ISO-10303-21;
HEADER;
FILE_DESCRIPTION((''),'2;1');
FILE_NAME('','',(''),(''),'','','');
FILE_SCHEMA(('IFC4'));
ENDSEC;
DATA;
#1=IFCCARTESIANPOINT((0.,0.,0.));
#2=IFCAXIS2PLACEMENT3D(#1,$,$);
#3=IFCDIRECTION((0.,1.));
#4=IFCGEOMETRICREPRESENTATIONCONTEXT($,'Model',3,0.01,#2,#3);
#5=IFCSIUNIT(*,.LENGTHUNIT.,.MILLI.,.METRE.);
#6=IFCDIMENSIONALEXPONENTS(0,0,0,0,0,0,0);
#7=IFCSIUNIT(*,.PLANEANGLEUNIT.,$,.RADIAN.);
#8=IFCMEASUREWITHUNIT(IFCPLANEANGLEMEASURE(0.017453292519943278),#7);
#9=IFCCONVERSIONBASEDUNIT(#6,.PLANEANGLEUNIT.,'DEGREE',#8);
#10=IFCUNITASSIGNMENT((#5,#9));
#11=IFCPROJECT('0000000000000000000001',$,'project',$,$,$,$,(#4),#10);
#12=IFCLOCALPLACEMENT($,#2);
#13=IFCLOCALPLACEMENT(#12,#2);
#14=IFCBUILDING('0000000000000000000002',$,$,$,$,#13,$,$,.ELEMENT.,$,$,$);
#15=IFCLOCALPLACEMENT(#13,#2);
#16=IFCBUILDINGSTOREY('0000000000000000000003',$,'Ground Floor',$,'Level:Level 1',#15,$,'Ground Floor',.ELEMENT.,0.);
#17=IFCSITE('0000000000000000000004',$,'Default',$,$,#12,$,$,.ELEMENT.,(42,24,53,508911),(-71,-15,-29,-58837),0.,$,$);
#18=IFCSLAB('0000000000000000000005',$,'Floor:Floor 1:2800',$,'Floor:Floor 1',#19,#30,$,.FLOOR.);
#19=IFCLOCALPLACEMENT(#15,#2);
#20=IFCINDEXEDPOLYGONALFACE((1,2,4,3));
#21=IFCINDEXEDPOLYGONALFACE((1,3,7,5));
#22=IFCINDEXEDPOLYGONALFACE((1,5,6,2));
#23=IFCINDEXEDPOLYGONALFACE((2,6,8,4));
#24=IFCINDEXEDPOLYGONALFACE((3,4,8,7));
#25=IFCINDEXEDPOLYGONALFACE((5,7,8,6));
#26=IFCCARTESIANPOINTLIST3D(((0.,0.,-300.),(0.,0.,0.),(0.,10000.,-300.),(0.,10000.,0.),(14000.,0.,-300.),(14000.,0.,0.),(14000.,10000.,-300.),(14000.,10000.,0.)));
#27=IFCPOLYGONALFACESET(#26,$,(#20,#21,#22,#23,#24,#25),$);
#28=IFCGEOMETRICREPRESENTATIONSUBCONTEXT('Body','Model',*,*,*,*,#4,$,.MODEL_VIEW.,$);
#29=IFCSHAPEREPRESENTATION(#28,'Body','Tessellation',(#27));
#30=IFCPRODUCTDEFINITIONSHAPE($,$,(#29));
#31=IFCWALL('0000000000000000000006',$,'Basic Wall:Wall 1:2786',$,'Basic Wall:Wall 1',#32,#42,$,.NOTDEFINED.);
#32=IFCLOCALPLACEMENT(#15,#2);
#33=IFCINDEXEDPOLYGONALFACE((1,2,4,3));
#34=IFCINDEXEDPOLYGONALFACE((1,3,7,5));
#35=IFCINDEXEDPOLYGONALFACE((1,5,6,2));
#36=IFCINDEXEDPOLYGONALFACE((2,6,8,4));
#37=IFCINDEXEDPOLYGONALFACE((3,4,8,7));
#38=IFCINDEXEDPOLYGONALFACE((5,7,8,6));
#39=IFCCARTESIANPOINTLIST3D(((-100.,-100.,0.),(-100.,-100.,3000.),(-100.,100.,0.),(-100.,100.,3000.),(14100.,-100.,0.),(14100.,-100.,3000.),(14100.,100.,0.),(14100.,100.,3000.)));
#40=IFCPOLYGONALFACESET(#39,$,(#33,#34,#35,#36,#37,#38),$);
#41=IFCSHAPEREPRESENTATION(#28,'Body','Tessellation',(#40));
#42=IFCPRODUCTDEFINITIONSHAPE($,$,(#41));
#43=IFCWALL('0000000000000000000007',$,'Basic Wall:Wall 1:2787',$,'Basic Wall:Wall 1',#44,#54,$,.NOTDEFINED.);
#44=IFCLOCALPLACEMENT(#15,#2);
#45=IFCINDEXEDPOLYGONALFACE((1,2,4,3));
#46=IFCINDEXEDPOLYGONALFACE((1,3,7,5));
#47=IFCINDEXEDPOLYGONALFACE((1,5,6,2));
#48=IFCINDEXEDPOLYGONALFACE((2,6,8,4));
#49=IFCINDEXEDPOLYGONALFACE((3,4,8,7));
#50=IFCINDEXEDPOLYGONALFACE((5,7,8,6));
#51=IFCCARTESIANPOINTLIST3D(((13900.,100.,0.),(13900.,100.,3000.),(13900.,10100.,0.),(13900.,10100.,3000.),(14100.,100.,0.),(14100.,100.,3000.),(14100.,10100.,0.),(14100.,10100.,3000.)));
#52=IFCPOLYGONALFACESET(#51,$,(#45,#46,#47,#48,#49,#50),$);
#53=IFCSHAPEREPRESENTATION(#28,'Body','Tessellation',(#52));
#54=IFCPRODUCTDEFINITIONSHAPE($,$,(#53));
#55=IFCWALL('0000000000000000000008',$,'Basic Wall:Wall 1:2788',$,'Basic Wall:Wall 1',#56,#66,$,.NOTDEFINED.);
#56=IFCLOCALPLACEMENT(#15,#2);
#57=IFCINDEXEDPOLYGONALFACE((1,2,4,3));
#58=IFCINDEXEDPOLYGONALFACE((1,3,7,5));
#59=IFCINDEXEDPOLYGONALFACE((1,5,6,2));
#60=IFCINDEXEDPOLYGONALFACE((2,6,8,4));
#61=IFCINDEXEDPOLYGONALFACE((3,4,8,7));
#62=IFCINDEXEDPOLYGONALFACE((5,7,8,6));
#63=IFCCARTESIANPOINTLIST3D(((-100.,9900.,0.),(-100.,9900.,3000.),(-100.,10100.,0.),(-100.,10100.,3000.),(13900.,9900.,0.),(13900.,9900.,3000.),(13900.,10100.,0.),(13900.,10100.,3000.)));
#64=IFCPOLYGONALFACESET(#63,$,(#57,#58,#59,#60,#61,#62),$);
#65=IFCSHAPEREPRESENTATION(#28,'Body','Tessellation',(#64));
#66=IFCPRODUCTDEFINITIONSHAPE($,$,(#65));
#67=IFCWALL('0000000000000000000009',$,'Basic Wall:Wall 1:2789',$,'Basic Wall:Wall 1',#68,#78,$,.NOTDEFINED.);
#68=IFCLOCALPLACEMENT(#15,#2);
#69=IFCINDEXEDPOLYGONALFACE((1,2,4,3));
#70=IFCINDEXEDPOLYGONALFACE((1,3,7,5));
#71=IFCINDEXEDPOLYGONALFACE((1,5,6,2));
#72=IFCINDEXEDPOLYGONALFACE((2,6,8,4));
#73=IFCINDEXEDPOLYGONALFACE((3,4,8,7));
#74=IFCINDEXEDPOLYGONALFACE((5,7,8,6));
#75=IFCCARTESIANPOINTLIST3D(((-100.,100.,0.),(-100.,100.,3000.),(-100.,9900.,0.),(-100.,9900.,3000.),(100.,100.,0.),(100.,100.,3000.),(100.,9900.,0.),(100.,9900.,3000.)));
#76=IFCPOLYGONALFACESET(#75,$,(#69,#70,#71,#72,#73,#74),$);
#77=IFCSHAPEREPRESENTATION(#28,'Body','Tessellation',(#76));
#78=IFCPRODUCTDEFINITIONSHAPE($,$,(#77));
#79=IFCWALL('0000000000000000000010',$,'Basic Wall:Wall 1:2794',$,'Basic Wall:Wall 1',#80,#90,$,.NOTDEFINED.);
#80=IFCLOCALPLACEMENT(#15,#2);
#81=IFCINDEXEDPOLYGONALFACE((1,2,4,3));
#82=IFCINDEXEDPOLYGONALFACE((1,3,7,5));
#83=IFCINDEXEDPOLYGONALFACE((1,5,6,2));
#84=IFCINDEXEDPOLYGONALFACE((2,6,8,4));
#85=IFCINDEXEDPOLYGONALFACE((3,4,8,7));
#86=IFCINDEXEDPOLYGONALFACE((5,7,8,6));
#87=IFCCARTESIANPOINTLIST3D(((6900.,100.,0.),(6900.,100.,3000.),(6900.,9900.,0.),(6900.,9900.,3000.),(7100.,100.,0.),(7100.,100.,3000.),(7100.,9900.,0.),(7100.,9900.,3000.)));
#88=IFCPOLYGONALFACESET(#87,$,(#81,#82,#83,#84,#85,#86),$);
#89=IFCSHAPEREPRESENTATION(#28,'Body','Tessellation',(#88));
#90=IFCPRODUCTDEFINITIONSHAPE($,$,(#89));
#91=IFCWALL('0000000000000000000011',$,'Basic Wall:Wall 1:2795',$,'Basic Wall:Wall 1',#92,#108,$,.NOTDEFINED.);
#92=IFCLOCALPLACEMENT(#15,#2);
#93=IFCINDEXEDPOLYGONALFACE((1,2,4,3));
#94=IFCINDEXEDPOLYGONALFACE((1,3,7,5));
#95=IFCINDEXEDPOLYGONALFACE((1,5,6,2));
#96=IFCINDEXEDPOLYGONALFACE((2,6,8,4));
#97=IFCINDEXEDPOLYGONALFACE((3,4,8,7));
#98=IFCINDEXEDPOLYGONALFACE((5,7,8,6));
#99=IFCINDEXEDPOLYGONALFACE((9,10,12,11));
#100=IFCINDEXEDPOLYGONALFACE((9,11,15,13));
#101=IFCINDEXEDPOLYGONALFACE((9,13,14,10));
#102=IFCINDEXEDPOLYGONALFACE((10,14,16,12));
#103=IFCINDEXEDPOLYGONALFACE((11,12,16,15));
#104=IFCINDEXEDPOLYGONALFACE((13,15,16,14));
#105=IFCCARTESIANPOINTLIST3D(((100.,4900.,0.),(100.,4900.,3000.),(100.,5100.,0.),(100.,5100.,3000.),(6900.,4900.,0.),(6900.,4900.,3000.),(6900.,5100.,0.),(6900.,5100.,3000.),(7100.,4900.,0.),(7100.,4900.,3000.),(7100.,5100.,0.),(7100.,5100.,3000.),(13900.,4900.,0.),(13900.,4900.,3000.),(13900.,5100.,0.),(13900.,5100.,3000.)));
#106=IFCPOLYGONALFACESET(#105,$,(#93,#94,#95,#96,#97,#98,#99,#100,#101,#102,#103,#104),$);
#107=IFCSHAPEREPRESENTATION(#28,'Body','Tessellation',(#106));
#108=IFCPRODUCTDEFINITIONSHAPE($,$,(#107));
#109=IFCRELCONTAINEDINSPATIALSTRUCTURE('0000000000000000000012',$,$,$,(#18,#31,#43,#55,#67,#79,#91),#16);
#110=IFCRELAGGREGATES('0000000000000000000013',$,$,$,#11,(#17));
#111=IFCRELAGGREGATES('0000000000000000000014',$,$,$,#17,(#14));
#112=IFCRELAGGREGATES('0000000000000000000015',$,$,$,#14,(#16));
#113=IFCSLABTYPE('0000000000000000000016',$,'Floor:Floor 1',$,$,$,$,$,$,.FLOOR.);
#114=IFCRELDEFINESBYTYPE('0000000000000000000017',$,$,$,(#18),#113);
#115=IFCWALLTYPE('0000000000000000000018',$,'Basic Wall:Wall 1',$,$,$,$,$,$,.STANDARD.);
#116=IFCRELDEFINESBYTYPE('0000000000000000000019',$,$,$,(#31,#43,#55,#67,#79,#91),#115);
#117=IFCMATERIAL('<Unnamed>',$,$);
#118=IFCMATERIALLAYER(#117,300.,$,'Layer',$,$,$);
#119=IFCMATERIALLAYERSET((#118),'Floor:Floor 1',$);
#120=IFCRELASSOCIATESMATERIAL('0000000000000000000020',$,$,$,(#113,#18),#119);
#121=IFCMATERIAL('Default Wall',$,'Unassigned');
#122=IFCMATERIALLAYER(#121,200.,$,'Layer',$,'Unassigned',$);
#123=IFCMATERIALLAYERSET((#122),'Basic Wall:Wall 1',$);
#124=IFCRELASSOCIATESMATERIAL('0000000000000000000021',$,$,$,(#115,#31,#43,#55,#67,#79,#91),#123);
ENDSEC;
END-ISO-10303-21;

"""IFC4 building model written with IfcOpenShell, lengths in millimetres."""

from ifc_helpers import new_model, entity, si_unit, converted_unit, direction, frame, frame_2d, origin, origin_2d_with_axis, place, context, subcontext, project, spatial, rectangle, extrude, material, layer, layer_set, layer_usage, type_object, element, save


model = new_model("IFC4")

# Units and contexts
model_context = context("Model", 3, precision=0.01, world=origin(), true_north=direction((0.0, 1.0)))
body_context = subcontext(model_context, "Body", "Model", "MODEL_VIEW")
ifc_project = project(units=[si_unit("LENGTHUNIT", "METRE", prefix="MILLI"), converted_unit("PLANEANGLEUNIT", "DEGREE", entity("IfcPlaneAngleMeasure", 0.017453292519943278), si_unit("PLANEANGLEUNIT", "RADIAN"), dimensions=[0, 0, 0, 0, 0, 0, 0])], contexts=[model_context])

# Site, building, storey
site_placement = place(None, origin())
site = spatial("IfcSite", under=ifc_project, at=site_placement, Name="Default", CompositionType="ELEMENT", RefLatitude=(42, 24, 53, 508911), RefLongitude=(-71, -15, -29, -58837), RefElevation=0.0)
building_placement = place(site_placement, origin())
building = spatial("IfcBuilding", under=site, at=building_placement, CompositionType="ELEMENT")
storey_placement = place(building_placement, origin())
storey = spatial("IfcBuildingStorey", under=building, at=storey_placement, Name="Ground Floor", ObjectType="Level:Level 1", LongName="Ground Floor", CompositionType="ELEMENT", Elevation=0.0)

# Slab
ifc_material_1 = material(Name="<Unnamed>")
ifc_layer_1 = layer(ifc_material_1, 300.0, Name="Layer")
ifc_layer_set_1 = layer_set([ifc_layer_1], Name="Floor:Floor 1")
ifc_layer_usage_1 = layer_usage(ifc_layer_set_1, "AXIS3", "POSITIVE", 0.0)
slab_type = type_object("IfcSlabType", Name="Floor:Floor 1", PredefinedType="FLOOR", material=ifc_layer_set_1)
slab_placement = place(storey_placement, origin())
element("IfcSlab", 1, at=slab_placement, inside=storey, type_object=slab_type, material=ifc_layer_usage_1, Name="Floor:Floor 1:2800", ObjectType="Floor:Floor 1", PredefinedType="FLOOR", context=body_context, shape_type="SweptSolid", body=[
    extrude(rectangle(XDim=10000.0, YDim=14000.0, at=origin_2d_with_axis()), frame((7000.0, 5000.0, 0.0), z_axis=(0.0, 0.0, -1.0), x_axis=(0.0, 1.0, 0.0)), (0.0, 0.0, 1.0), 300.0),
])

# Walls
ifc_material_2 = material(Name="Default Wall", Category="Unassigned")
ifc_layer_2 = layer(ifc_material_2, 200.0, Name="Layer", Category="Unassigned")
ifc_layer_set_2 = layer_set([ifc_layer_2], Name="Basic Wall:Wall 1")
ifc_layer_usage_2 = layer_usage(ifc_layer_set_2, "AXIS2", "NEGATIVE", 100.0)
wall_type = type_object("IfcWallType", Name="Basic Wall:Wall 1", PredefinedType="STANDARD", material=ifc_layer_set_2)
wall_1_placement = place(storey_placement, frame((-100.0, 0.0, 0.0)))
element("IfcWall", 2, at=wall_1_placement, inside=storey, type_object=wall_type, material=ifc_layer_usage_2, Name="Basic Wall:Wall 1:2786", ObjectType="Basic Wall:Wall 1", PredefinedType="NOTDEFINED", context=body_context, shape_type="SweptSolid", body=[
    extrude(rectangle(XDim=14200.0, YDim=200.0, at=frame_2d((7100.0, 0.0), x_axis=(-1.0, 0.0))), origin(), (0.0, 0.0, 1.0), 3000.0),
])
ifc_layer_usage_3 = layer_usage(ifc_layer_set_2, "AXIS2", "NEGATIVE", 100.0)
wall_2_placement = place(storey_placement, frame((14000.0, 100.0, 0.0), z_axis=(0.0, 0.0, 1.0), x_axis=(0.0, 1.0, 0.0)))
element("IfcWall", 3, at=wall_2_placement, inside=storey, type_object=wall_type, material=ifc_layer_usage_3, Name="Basic Wall:Wall 1:2787", ObjectType="Basic Wall:Wall 1", PredefinedType="NOTDEFINED", context=body_context, shape_type="SweptSolid", body=[
    extrude(rectangle(XDim=10000.0, YDim=200.0, at=frame_2d((5000.0, 0.0), x_axis=(-1.0, 0.0))), origin(), (0.0, 0.0, 1.0), 3000.0),
])
ifc_layer_usage_4 = layer_usage(ifc_layer_set_2, "AXIS2", "NEGATIVE", 100.0)
wall_3_placement = place(storey_placement, frame((13900.0, 10000.0, 0.0), z_axis=(0.0, 0.0, 1.0), x_axis=(-1.0, 0.0, 0.0)))
element("IfcWall", 4, at=wall_3_placement, inside=storey, type_object=wall_type, material=ifc_layer_usage_4, Name="Basic Wall:Wall 1:2788", ObjectType="Basic Wall:Wall 1", PredefinedType="NOTDEFINED", context=body_context, shape_type="SweptSolid", body=[
    extrude(rectangle(XDim=14000.0, YDim=200.0, at=frame_2d((7000.0, 0.0), x_axis=(-1.0, 0.0))), origin(), (0.0, 0.0, 1.0), 3000.0),
])
ifc_layer_usage_5 = layer_usage(ifc_layer_set_2, "AXIS2", "NEGATIVE", 100.0)
wall_4_placement = place(storey_placement, frame((0.0, 9900.0, 0.0), z_axis=(0.0, 0.0, 1.0), x_axis=(0.0, -1.0, 0.0)))
element("IfcWall", 5, at=wall_4_placement, inside=storey, type_object=wall_type, material=ifc_layer_usage_5, Name="Basic Wall:Wall 1:2789", ObjectType="Basic Wall:Wall 1", PredefinedType="NOTDEFINED", context=body_context, shape_type="SweptSolid", body=[
    extrude(rectangle(XDim=9800.0, YDim=200.0, at=frame_2d((4900.0, 0.0), x_axis=(-1.0, 0.0))), origin(), (0.0, 0.0, 1.0), 3000.0),
])
ifc_layer_usage_6 = layer_usage(ifc_layer_set_2, "AXIS2", "NEGATIVE", 100.0)
wall_5_placement = place(storey_placement, frame((7000.0, 100.0, 0.0), z_axis=(0.0, 0.0, 1.0), x_axis=(0.0, 1.0, 0.0)))
element("IfcWall", 6, at=wall_5_placement, inside=storey, type_object=wall_type, material=ifc_layer_usage_6, Name="Basic Wall:Wall 1:2794", ObjectType="Basic Wall:Wall 1", PredefinedType="NOTDEFINED", context=body_context, shape_type="SweptSolid", body=[
    extrude(rectangle(XDim=9800.0, YDim=200.0, at=frame_2d((4900.0, 0.0), x_axis=(-1.0, 0.0))), origin(), (0.0, 0.0, 1.0), 3000.0),
])

# Wall, opening
ifc_layer_usage_7 = layer_usage(ifc_layer_set_2, "AXIS2", "NEGATIVE", 100.0)
wall_6_placement = place(storey_placement, frame((100.0, 5000.0, 0.0)))
wall_6 = element("IfcWall", 7, at=wall_6_placement, inside=storey, type_object=wall_type, material=ifc_layer_usage_7, Name="Basic Wall:Wall 1:2795", ObjectType="Basic Wall:Wall 1", PredefinedType="NOTDEFINED", context=body_context, shape_type="SweptSolid", body=[
    extrude(rectangle(XDim=13800.0, YDim=200.0, at=frame_2d((6900.0, 0.0), x_axis=(-1.0, 0.0))), origin(), (0.0, 0.0, 1.0), 3000.0),
])
opening_placement = place(storey_placement, frame((100.0, 5000.0, 0.0)))
element("IfcOpeningElement", 8, at=opening_placement, cuts=wall_6, PredefinedType="OPENING", context=body_context, shape_type="SweptSolid", body=[
    extrude(rectangle(XDim=3000.0, YDim=200.0, at=origin_2d_with_axis()), frame((6800.0, 0.0, 1500.0), z_axis=(1.0, 0.0, 0.0), x_axis=(0.0, 0.0, -1.0)), (0.0, 0.0, 1.0), 200.0),
])

save(model, "model.ifc")
